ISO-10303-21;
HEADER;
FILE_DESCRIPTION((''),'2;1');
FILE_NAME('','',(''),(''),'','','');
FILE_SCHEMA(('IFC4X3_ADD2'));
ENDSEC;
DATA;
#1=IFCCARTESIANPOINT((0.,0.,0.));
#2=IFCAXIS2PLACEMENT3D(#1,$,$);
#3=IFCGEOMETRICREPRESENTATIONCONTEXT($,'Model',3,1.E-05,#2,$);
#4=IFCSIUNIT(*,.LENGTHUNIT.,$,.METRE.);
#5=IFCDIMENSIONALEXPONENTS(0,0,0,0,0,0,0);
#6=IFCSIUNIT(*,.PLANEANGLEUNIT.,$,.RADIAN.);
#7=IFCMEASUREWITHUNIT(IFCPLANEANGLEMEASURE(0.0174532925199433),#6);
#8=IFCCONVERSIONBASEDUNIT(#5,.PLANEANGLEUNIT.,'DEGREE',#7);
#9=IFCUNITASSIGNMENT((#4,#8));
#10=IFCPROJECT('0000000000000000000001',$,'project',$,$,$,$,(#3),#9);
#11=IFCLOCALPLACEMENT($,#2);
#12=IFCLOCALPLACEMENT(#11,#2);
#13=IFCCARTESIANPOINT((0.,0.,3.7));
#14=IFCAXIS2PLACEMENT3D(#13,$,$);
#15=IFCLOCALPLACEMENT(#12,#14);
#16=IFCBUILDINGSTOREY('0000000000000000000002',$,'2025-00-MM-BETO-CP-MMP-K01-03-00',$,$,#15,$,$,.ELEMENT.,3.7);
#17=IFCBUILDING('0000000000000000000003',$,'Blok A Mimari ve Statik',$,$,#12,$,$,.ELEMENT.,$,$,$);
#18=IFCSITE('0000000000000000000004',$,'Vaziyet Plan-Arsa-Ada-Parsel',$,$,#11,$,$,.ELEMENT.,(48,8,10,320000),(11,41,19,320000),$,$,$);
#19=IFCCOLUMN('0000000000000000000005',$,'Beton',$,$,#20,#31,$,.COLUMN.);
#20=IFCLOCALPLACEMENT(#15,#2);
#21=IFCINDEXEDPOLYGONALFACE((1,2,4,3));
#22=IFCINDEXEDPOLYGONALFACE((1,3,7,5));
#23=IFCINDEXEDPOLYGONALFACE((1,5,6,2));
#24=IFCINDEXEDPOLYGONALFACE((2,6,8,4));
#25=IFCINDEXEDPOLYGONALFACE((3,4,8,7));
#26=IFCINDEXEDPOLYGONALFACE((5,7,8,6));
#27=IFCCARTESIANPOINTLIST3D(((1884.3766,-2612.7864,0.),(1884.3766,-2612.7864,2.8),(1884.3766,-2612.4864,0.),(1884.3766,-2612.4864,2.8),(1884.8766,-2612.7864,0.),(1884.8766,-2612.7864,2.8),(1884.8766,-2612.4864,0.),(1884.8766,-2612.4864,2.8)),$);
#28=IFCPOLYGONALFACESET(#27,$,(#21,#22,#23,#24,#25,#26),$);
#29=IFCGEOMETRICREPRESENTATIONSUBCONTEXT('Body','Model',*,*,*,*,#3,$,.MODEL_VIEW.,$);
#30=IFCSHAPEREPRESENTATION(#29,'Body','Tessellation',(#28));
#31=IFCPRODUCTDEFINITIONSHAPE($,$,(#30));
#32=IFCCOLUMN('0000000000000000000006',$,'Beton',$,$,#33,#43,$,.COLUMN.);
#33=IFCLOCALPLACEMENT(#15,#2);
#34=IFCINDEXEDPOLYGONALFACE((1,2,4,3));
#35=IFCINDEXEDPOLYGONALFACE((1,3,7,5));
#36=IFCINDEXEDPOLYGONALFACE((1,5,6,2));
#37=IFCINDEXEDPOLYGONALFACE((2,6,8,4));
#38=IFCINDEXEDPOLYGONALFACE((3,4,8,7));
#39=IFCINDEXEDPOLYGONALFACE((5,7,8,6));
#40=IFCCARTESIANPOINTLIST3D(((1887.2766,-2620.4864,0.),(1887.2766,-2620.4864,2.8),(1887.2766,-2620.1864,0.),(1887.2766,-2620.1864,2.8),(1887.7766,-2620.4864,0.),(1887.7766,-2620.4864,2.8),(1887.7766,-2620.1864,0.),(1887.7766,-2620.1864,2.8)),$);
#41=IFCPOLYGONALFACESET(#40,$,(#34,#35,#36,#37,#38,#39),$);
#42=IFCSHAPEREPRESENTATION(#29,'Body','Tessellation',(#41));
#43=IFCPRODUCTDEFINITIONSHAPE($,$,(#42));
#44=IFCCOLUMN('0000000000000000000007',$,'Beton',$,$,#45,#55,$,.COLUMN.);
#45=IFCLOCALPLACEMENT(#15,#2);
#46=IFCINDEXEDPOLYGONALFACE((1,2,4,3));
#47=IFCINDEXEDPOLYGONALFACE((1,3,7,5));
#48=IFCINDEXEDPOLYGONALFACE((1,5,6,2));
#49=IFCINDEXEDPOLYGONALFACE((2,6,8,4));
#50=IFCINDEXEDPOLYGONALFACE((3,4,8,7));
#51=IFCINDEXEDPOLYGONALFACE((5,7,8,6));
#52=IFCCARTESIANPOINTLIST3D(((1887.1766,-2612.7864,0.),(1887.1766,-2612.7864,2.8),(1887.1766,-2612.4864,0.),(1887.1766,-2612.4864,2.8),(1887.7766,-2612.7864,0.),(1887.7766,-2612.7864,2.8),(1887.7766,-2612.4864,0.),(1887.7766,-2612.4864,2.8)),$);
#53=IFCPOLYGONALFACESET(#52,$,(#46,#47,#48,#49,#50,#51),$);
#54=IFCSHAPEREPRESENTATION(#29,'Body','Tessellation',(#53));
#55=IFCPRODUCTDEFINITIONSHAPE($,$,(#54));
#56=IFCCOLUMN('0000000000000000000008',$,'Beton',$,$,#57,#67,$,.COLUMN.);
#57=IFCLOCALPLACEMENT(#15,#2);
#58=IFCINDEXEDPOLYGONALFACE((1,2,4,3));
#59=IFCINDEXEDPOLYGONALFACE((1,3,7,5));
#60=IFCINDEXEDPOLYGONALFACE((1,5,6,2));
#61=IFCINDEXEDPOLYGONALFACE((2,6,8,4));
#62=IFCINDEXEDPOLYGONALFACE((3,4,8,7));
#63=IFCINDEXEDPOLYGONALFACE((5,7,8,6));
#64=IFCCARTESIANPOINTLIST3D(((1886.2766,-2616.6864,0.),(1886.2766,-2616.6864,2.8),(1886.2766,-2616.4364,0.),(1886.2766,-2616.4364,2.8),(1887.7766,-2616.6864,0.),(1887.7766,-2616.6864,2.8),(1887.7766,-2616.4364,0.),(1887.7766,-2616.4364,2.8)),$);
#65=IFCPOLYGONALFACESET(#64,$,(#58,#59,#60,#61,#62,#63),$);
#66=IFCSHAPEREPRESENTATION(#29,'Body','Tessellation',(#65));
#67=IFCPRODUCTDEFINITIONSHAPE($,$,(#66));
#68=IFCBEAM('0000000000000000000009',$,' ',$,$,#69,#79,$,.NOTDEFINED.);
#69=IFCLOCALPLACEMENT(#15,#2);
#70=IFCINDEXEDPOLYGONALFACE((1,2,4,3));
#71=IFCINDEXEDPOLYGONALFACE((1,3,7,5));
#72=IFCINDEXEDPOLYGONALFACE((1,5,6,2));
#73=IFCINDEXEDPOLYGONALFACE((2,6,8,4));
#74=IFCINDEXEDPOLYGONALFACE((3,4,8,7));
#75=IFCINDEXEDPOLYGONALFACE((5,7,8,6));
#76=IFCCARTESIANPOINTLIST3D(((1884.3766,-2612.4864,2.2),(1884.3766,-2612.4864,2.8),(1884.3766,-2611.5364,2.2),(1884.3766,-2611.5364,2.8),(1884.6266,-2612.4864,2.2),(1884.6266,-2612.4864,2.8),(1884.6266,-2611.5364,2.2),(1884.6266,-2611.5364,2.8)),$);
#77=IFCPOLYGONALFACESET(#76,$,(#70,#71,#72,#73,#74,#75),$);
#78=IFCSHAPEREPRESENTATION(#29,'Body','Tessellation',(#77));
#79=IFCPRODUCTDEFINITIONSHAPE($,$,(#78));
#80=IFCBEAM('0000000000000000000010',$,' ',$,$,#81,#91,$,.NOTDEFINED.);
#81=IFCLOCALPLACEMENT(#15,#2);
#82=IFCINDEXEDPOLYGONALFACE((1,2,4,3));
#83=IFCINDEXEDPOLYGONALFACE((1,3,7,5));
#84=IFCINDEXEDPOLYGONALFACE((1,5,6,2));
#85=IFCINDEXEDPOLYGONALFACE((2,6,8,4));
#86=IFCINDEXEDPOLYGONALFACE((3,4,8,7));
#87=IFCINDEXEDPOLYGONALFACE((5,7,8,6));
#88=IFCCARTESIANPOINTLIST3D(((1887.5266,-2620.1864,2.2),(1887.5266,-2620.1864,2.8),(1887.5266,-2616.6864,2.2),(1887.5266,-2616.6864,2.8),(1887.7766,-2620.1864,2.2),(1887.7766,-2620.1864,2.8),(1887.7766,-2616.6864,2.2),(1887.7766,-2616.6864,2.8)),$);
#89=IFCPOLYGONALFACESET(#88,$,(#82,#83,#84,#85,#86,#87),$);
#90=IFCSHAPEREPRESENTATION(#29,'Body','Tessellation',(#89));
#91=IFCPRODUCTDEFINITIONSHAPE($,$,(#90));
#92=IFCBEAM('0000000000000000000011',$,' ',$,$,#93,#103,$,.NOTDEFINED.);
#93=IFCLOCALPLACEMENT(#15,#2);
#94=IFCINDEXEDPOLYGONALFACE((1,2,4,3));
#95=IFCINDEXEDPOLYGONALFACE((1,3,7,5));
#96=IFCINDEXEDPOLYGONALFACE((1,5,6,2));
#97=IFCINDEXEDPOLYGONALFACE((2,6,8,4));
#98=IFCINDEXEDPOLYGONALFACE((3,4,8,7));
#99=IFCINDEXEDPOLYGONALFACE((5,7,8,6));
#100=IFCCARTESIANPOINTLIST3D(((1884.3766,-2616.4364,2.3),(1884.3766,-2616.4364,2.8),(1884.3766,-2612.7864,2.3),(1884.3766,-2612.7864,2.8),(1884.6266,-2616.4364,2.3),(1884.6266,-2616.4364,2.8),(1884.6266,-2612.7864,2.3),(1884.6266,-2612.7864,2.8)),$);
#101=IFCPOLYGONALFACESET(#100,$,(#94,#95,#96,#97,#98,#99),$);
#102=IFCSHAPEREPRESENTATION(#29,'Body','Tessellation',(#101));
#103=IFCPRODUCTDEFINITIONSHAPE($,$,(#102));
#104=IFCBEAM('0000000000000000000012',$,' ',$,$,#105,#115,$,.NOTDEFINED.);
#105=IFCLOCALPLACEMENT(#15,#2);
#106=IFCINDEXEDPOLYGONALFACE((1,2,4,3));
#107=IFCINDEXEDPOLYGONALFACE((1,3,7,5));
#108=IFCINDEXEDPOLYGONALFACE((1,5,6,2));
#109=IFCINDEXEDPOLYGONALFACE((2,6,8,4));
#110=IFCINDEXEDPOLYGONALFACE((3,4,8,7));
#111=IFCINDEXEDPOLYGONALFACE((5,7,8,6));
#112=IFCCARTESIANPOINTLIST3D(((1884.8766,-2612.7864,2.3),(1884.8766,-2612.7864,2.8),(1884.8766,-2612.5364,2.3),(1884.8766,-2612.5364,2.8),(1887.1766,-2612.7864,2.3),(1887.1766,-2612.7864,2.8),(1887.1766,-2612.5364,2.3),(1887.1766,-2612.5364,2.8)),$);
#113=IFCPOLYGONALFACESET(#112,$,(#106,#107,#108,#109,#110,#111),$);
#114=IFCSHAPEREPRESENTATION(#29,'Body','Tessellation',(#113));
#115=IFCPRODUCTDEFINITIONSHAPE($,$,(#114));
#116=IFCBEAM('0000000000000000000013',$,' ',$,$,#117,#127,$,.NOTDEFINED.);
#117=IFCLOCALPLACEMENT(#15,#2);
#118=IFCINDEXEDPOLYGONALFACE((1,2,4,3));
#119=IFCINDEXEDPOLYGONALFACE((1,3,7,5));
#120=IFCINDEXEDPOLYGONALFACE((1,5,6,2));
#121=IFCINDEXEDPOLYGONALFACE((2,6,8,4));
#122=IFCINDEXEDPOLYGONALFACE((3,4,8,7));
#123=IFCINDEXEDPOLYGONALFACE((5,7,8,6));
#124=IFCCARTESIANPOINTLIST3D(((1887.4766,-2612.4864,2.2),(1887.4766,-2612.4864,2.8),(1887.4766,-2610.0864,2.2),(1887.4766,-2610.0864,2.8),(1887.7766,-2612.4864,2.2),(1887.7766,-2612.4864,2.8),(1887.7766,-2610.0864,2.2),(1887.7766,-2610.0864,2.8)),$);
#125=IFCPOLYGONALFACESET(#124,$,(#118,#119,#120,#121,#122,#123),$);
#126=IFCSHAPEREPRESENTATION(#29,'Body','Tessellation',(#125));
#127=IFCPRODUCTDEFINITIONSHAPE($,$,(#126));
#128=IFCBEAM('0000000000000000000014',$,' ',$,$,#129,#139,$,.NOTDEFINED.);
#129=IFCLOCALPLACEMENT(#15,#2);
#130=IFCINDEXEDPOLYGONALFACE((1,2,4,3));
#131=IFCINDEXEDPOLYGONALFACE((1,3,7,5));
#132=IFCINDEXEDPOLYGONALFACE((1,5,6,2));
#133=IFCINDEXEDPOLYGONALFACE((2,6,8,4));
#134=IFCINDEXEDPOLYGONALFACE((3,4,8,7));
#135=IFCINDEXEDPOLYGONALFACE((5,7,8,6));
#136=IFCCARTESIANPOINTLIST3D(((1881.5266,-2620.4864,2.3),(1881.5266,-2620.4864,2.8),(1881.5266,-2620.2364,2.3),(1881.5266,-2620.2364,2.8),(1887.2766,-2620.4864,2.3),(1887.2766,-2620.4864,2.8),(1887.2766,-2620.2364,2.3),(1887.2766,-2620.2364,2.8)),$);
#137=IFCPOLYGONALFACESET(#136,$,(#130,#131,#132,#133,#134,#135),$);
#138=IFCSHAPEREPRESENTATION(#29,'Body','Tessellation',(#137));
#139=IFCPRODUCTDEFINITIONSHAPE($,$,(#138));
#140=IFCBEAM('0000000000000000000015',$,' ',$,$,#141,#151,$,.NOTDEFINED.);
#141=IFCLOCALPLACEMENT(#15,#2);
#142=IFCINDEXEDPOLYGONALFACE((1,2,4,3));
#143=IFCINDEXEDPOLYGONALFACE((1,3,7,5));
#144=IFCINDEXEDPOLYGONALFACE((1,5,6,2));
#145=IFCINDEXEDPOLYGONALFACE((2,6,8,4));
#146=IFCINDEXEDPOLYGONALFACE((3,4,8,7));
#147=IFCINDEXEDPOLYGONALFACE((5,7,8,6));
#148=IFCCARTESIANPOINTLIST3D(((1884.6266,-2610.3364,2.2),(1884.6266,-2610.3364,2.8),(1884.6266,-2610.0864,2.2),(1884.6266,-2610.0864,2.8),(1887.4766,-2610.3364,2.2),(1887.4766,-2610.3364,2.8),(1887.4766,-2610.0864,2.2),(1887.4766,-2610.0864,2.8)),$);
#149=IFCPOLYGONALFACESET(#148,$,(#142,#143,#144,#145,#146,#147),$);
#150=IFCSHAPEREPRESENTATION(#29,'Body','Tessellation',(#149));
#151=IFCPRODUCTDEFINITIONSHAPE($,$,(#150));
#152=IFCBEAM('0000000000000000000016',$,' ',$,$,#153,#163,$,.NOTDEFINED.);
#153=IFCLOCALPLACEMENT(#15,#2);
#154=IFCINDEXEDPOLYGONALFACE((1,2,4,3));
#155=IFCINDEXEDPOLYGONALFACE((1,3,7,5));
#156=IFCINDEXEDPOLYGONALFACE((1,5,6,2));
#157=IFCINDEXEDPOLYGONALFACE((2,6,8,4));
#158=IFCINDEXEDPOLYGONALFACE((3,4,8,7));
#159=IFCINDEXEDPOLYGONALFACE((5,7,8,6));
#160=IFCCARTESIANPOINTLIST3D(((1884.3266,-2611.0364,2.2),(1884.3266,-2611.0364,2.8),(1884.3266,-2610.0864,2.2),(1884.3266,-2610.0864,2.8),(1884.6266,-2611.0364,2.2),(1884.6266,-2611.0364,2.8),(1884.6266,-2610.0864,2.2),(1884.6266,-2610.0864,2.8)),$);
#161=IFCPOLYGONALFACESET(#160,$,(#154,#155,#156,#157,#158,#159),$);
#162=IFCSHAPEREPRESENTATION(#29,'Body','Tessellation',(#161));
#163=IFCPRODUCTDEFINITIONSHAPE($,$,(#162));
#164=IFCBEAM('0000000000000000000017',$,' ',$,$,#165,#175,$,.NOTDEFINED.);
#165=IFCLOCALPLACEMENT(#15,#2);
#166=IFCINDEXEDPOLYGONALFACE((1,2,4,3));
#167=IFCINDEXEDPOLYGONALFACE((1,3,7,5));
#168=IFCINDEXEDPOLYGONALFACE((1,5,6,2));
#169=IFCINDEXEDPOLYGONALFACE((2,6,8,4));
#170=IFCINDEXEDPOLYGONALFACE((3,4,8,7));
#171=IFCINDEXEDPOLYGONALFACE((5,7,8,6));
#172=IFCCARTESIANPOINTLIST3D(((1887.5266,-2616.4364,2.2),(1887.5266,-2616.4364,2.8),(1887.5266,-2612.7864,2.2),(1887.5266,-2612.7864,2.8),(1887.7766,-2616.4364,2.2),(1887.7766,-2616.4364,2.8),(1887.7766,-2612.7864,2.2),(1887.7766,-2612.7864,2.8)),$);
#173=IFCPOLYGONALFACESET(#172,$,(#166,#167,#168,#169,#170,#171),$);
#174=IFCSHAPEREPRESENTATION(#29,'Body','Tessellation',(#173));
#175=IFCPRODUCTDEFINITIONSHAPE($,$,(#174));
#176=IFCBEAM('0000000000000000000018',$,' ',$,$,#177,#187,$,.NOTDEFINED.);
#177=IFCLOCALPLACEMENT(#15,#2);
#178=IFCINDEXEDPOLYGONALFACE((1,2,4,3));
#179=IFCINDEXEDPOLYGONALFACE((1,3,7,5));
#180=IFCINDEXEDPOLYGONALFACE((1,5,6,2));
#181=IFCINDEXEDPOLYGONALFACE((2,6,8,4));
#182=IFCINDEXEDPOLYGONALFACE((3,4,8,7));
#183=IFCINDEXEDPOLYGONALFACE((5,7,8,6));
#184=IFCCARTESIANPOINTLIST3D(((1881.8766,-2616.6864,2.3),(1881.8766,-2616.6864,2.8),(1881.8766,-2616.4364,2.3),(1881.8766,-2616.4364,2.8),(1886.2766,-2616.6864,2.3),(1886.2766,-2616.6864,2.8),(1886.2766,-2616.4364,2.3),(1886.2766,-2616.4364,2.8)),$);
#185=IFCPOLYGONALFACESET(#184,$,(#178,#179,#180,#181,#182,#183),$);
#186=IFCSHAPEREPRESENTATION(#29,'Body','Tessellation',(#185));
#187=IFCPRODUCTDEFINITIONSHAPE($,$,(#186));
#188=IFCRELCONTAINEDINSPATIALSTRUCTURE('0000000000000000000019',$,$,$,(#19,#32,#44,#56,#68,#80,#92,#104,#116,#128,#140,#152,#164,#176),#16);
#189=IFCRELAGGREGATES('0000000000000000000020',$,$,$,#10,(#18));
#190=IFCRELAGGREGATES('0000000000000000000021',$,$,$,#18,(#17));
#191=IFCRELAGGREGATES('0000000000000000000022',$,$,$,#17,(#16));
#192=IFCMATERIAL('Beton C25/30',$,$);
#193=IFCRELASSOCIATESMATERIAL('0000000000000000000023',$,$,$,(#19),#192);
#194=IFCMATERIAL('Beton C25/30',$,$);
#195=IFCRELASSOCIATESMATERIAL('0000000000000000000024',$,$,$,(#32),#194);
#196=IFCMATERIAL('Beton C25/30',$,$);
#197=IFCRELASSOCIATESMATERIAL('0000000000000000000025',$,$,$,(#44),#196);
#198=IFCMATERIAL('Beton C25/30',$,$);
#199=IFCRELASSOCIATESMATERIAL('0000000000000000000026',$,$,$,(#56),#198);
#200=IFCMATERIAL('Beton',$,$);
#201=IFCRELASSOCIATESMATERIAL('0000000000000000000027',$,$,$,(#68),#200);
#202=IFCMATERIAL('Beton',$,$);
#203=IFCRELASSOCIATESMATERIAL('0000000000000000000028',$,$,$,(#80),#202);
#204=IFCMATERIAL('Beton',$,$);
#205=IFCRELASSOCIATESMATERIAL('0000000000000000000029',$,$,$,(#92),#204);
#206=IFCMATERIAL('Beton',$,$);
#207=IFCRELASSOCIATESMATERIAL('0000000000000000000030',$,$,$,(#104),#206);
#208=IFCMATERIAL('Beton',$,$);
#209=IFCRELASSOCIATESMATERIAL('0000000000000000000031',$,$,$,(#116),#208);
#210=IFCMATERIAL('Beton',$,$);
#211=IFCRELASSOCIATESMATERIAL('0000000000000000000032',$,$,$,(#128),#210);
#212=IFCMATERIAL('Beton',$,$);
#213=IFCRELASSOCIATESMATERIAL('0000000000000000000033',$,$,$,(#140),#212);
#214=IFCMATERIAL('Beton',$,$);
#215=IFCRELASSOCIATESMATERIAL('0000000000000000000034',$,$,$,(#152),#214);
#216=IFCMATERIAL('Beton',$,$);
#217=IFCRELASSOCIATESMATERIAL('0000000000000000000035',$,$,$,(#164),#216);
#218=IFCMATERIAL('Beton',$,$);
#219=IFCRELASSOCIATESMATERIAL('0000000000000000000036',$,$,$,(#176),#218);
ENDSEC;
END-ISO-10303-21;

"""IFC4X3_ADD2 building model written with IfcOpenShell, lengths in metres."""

from ifc_helpers import new_model, entity, si_unit, converted_unit, frame, frame_2d, origin, origin_with_axes, place, context, subcontext, project, spatial, polyline, rectangle, outline, extrude, material, element, save


model = new_model("IFC4X3_ADD2")

# Units and contexts
model_context = context("Model", 3, precision=1e-05, world=origin())
body_context = subcontext(model_context, "Body", "Model", "MODEL_VIEW")
ifc_project = project(units=[si_unit("LENGTHUNIT", "METRE"), converted_unit("PLANEANGLEUNIT", "DEGREE", entity("IfcPlaneAngleMeasure", 0.0174532925199433), si_unit("PLANEANGLEUNIT", "RADIAN"), dimensions=[0, 0, 0, 0, 0, 0, 0])], contexts=[model_context])

# Site, building, storey
site_placement = place(None, origin())
site = spatial("IfcSite", under=ifc_project, at=site_placement, Name="Vaziyet Plan-Arsa-Ada-Parsel", CompositionType="ELEMENT", RefLatitude=(48, 8, 10, 320000), RefLongitude=(11, 41, 19, 320000))
building_placement = place(site_placement, origin())
building = spatial("IfcBuilding", under=site, at=building_placement, Name="Blok A Mimari ve Statik", CompositionType="ELEMENT")
storey_placement = place(building_placement, frame((0.0, 0.0, 3.7)))
storey = spatial("IfcBuildingStorey", under=building, at=storey_placement, Name="2025-00-MM-BETO-CP-MMP-K01-03-00", CompositionType="ELEMENT", Elevation=3.7)

# Columns
ifc_material_1 = material(Name="Beton C25/30")
column_1_placement = place(storey_placement, frame((1884.3766, -2612.7864, 0.0)))
element("IfcColumn", 1, at=column_1_placement, inside=storey, material=ifc_material_1, Name="Beton", PredefinedType="COLUMN", context=body_context, shape_type="SweptSolid", body=[
    extrude(outline(polyline([(0.0, 0.3), (0.0, 0.0), (0.5, 0.0), (0.5, 0.3), (0.0, 0.3)])), origin_with_axes(), (0.0, 0.0, 1.0), 2.8),
])
ifc_material_2 = material(Name="Beton C25/30")
column_2_placement = place(storey_placement, frame((1887.2766, -2620.4864, 0.0)))
element("IfcColumn", 2, at=column_2_placement, inside=storey, material=ifc_material_2, Name="Beton", PredefinedType="COLUMN", context=body_context, shape_type="SweptSolid", body=[
    extrude(outline(polyline([(0.0, 0.3), (0.0, 0.0), (0.5, 0.0), (0.5, 0.3), (0.0, 0.3)])), origin_with_axes(), (0.0, 0.0, 1.0), 2.8),
])
ifc_material_3 = material(Name="Beton C25/30")
column_3_placement = place(storey_placement, frame((1887.1766, -2612.7864, 0.0)))
element("IfcColumn", 3, at=column_3_placement, inside=storey, material=ifc_material_3, Name="Beton", PredefinedType="COLUMN", context=body_context, shape_type="SweptSolid", body=[
    extrude(outline(polyline([(0.0, 0.3), (0.0, 0.0), (0.6, 0.0), (0.6, 0.3), (0.0, 0.3)])), origin_with_axes(), (0.0, 0.0, 1.0), 2.8),
])
ifc_material_4 = material(Name="Beton C25/30")
column_4_placement = place(storey_placement, frame((1886.2766, -2616.6864, 0.0)))
element("IfcColumn", 4, at=column_4_placement, inside=storey, material=ifc_material_4, Name="Beton", PredefinedType="COLUMN", context=body_context, shape_type="SweptSolid", body=[
    extrude(outline(polyline([(0.0, 0.25), (0.0, 0.0), (1.5, 0.0), (1.5, 0.25), (0.0, 0.25)])), origin_with_axes(), (0.0, 0.0, 1.0), 2.8),
])

# Beams
ifc_material_5 = material(Name="Beton")
beam_1_placement = place(storey_placement, frame((1884.3766, -2611.5364, 2.2), z_axis=(0.0, 0.0, 1.0), x_axis=(0.0, -1.0, 0.0)))
element("IfcBeam", 5, at=beam_1_placement, inside=storey, material=ifc_material_5, Name=" ", PredefinedType="NOTDEFINED", context=body_context, shape_type="SweptSolid", body=[
    extrude(rectangle(XDim=0.25, YDim=0.6, at=frame_2d((0.125, 0.3), x_axis=(1.0, 0.0))), frame((0.0, 0.0, 0.0), z_axis=(1.0, 0.0, 0.0), x_axis=(0.0, 1.0, 0.0)), (0.0, 0.0, 1.0), 0.95),
])
ifc_material_6 = material(Name="Beton")
beam_2_placement = place(storey_placement, frame((1887.7766, -2620.1864, 2.2), z_axis=(0.0, 0.0, 1.0), x_axis=(0.0, 1.0, 0.0)))
element("IfcBeam", 6, at=beam_2_placement, inside=storey, material=ifc_material_6, Name=" ", PredefinedType="NOTDEFINED", context=body_context, shape_type="SweptSolid", body=[
    extrude(rectangle(XDim=0.25, YDim=0.6, at=frame_2d((0.125, 0.3), x_axis=(1.0, 0.0))), frame((0.0, 0.0, 0.0), z_axis=(1.0, 0.0, 0.0), x_axis=(0.0, 1.0, 0.0)), (0.0, 0.0, 1.0), 3.5),
])
ifc_material_7 = material(Name="Beton")
beam_3_placement = place(storey_placement, frame((1884.6266, -2616.4364, 2.3), z_axis=(0.0, 0.0, 1.0), x_axis=(0.0, 1.0, 0.0)))
element("IfcBeam", 7, at=beam_3_placement, inside=storey, material=ifc_material_7, Name=" ", PredefinedType="NOTDEFINED", context=body_context, shape_type="SweptSolid", body=[
    extrude(rectangle(XDim=0.25, YDim=0.5, at=frame_2d((0.125, 0.25), x_axis=(1.0, 0.0))), frame((0.0, 0.0, 0.0), z_axis=(1.0, 0.0, 0.0), x_axis=(0.0, 1.0, 0.0)), (0.0, 0.0, 1.0), 3.65),
])
ifc_material_8 = material(Name="Beton")
beam_4_placement = place(storey_placement, frame((1884.8766, -2612.7864, 2.3)))
element("IfcBeam", 8, at=beam_4_placement, inside=storey, material=ifc_material_8, Name=" ", PredefinedType="NOTDEFINED", context=body_context, shape_type="SweptSolid", body=[
    extrude(rectangle(XDim=0.25, YDim=0.5, at=frame_2d((0.125, 0.25), x_axis=(1.0, 0.0))), frame((0.0, 0.0, 0.0), z_axis=(1.0, 0.0, 0.0), x_axis=(0.0, 1.0, 0.0)), (0.0, 0.0, 1.0), 2.3),
])
ifc_material_9 = material(Name="Beton")
beam_5_placement = place(storey_placement, frame((1887.7766, -2612.4864, 2.2), z_axis=(0.0, 0.0, 1.0), x_axis=(0.0, 1.0, 0.0)))
element("IfcBeam", 9, at=beam_5_placement, inside=storey, material=ifc_material_9, Name=" ", PredefinedType="NOTDEFINED", context=body_context, shape_type="SweptSolid", body=[
    extrude(rectangle(XDim=0.3, YDim=0.6, at=frame_2d((0.15, 0.3), x_axis=(1.0, 0.0))), frame((0.0, 0.0, 0.0), z_axis=(1.0, 0.0, 0.0), x_axis=(0.0, 1.0, 0.0)), (0.0, 0.0, 1.0), 2.4),
])
ifc_material_10 = material(Name="Beton")
beam_6_placement = place(storey_placement, frame((1887.2766, -2620.2364, 2.3), z_axis=(0.0, 0.0, 1.0), x_axis=(-1.0, 0.0, 0.0)))
element("IfcBeam", 10, at=beam_6_placement, inside=storey, material=ifc_material_10, Name=" ", PredefinedType="NOTDEFINED", context=body_context, shape_type="SweptSolid", body=[
    extrude(rectangle(XDim=0.25, YDim=0.5, at=frame_2d((0.125, 0.25), x_axis=(1.0, 0.0))), frame((0.0, 0.0, 0.0), z_axis=(1.0, 0.0, 0.0), x_axis=(0.0, 1.0, 0.0)), (0.0, 0.0, 1.0), 5.75),
])
ifc_material_11 = material(Name="Beton")
beam_7_placement = place(storey_placement, frame((1887.4766, -2610.0864, 2.2), z_axis=(0.0, 0.0, 1.0), x_axis=(-1.0, 0.0, 0.0)))
element("IfcBeam", 11, at=beam_7_placement, inside=storey, material=ifc_material_11, Name=" ", PredefinedType="NOTDEFINED", context=body_context, shape_type="SweptSolid", body=[
    extrude(rectangle(XDim=0.25, YDim=0.6, at=frame_2d((0.125, 0.3), x_axis=(1.0, 0.0))), frame((0.0, 0.0, 0.0), z_axis=(1.0, 0.0, 0.0), x_axis=(0.0, 1.0, 0.0)), (0.0, 0.0, 1.0), 2.85),
])
ifc_material_12 = material(Name="Beton")
beam_8_placement = place(storey_placement, frame((1884.3266, -2610.0864, 2.2), z_axis=(0.0, 0.0, 1.0), x_axis=(0.0, -1.0, 0.0)))
element("IfcBeam", 12, at=beam_8_placement, inside=storey, material=ifc_material_12, Name=" ", PredefinedType="NOTDEFINED", context=body_context, shape_type="SweptSolid", body=[
    extrude(rectangle(XDim=0.3, YDim=0.6, at=frame_2d((0.15, 0.3), x_axis=(1.0, 0.0))), frame((0.0, 0.0, 0.0), z_axis=(1.0, 0.0, 0.0), x_axis=(0.0, 1.0, 0.0)), (0.0, 0.0, 1.0), 0.95),
])
ifc_material_13 = material(Name="Beton")
beam_9_placement = place(storey_placement, frame((1887.7766, -2616.4364, 2.2), z_axis=(0.0, 0.0, 1.0), x_axis=(0.0, 1.0, 0.0)))
element("IfcBeam", 13, at=beam_9_placement, inside=storey, material=ifc_material_13, Name=" ", PredefinedType="NOTDEFINED", context=body_context, shape_type="SweptSolid", body=[
    extrude(rectangle(XDim=0.25, YDim=0.6, at=frame_2d((0.125, 0.3), x_axis=(1.0, 0.0))), frame((0.0, 0.0, 0.0), z_axis=(1.0, 0.0, 0.0), x_axis=(0.0, 1.0, 0.0)), (0.0, 0.0, 1.0), 3.65),
])
ifc_material_14 = material(Name="Beton")
beam_10_placement = place(storey_placement, frame((1886.2766, -2616.4364, 2.3), z_axis=(0.0, 0.0, 1.0), x_axis=(-1.0, 0.0, 0.0)))
element("IfcBeam", 14, at=beam_10_placement, inside=storey, material=ifc_material_14, Name=" ", PredefinedType="NOTDEFINED", context=body_context, shape_type="SweptSolid", body=[
    extrude(rectangle(XDim=0.25, YDim=0.5, at=frame_2d((0.125, 0.25), x_axis=(1.0, 0.0))), frame((0.0, 0.0, 0.0), z_axis=(1.0, 0.0, 0.0), x_axis=(0.0, 1.0, 0.0)), (0.0, 0.0, 1.0), 4.4),
])

save(model, "model.ifc")
